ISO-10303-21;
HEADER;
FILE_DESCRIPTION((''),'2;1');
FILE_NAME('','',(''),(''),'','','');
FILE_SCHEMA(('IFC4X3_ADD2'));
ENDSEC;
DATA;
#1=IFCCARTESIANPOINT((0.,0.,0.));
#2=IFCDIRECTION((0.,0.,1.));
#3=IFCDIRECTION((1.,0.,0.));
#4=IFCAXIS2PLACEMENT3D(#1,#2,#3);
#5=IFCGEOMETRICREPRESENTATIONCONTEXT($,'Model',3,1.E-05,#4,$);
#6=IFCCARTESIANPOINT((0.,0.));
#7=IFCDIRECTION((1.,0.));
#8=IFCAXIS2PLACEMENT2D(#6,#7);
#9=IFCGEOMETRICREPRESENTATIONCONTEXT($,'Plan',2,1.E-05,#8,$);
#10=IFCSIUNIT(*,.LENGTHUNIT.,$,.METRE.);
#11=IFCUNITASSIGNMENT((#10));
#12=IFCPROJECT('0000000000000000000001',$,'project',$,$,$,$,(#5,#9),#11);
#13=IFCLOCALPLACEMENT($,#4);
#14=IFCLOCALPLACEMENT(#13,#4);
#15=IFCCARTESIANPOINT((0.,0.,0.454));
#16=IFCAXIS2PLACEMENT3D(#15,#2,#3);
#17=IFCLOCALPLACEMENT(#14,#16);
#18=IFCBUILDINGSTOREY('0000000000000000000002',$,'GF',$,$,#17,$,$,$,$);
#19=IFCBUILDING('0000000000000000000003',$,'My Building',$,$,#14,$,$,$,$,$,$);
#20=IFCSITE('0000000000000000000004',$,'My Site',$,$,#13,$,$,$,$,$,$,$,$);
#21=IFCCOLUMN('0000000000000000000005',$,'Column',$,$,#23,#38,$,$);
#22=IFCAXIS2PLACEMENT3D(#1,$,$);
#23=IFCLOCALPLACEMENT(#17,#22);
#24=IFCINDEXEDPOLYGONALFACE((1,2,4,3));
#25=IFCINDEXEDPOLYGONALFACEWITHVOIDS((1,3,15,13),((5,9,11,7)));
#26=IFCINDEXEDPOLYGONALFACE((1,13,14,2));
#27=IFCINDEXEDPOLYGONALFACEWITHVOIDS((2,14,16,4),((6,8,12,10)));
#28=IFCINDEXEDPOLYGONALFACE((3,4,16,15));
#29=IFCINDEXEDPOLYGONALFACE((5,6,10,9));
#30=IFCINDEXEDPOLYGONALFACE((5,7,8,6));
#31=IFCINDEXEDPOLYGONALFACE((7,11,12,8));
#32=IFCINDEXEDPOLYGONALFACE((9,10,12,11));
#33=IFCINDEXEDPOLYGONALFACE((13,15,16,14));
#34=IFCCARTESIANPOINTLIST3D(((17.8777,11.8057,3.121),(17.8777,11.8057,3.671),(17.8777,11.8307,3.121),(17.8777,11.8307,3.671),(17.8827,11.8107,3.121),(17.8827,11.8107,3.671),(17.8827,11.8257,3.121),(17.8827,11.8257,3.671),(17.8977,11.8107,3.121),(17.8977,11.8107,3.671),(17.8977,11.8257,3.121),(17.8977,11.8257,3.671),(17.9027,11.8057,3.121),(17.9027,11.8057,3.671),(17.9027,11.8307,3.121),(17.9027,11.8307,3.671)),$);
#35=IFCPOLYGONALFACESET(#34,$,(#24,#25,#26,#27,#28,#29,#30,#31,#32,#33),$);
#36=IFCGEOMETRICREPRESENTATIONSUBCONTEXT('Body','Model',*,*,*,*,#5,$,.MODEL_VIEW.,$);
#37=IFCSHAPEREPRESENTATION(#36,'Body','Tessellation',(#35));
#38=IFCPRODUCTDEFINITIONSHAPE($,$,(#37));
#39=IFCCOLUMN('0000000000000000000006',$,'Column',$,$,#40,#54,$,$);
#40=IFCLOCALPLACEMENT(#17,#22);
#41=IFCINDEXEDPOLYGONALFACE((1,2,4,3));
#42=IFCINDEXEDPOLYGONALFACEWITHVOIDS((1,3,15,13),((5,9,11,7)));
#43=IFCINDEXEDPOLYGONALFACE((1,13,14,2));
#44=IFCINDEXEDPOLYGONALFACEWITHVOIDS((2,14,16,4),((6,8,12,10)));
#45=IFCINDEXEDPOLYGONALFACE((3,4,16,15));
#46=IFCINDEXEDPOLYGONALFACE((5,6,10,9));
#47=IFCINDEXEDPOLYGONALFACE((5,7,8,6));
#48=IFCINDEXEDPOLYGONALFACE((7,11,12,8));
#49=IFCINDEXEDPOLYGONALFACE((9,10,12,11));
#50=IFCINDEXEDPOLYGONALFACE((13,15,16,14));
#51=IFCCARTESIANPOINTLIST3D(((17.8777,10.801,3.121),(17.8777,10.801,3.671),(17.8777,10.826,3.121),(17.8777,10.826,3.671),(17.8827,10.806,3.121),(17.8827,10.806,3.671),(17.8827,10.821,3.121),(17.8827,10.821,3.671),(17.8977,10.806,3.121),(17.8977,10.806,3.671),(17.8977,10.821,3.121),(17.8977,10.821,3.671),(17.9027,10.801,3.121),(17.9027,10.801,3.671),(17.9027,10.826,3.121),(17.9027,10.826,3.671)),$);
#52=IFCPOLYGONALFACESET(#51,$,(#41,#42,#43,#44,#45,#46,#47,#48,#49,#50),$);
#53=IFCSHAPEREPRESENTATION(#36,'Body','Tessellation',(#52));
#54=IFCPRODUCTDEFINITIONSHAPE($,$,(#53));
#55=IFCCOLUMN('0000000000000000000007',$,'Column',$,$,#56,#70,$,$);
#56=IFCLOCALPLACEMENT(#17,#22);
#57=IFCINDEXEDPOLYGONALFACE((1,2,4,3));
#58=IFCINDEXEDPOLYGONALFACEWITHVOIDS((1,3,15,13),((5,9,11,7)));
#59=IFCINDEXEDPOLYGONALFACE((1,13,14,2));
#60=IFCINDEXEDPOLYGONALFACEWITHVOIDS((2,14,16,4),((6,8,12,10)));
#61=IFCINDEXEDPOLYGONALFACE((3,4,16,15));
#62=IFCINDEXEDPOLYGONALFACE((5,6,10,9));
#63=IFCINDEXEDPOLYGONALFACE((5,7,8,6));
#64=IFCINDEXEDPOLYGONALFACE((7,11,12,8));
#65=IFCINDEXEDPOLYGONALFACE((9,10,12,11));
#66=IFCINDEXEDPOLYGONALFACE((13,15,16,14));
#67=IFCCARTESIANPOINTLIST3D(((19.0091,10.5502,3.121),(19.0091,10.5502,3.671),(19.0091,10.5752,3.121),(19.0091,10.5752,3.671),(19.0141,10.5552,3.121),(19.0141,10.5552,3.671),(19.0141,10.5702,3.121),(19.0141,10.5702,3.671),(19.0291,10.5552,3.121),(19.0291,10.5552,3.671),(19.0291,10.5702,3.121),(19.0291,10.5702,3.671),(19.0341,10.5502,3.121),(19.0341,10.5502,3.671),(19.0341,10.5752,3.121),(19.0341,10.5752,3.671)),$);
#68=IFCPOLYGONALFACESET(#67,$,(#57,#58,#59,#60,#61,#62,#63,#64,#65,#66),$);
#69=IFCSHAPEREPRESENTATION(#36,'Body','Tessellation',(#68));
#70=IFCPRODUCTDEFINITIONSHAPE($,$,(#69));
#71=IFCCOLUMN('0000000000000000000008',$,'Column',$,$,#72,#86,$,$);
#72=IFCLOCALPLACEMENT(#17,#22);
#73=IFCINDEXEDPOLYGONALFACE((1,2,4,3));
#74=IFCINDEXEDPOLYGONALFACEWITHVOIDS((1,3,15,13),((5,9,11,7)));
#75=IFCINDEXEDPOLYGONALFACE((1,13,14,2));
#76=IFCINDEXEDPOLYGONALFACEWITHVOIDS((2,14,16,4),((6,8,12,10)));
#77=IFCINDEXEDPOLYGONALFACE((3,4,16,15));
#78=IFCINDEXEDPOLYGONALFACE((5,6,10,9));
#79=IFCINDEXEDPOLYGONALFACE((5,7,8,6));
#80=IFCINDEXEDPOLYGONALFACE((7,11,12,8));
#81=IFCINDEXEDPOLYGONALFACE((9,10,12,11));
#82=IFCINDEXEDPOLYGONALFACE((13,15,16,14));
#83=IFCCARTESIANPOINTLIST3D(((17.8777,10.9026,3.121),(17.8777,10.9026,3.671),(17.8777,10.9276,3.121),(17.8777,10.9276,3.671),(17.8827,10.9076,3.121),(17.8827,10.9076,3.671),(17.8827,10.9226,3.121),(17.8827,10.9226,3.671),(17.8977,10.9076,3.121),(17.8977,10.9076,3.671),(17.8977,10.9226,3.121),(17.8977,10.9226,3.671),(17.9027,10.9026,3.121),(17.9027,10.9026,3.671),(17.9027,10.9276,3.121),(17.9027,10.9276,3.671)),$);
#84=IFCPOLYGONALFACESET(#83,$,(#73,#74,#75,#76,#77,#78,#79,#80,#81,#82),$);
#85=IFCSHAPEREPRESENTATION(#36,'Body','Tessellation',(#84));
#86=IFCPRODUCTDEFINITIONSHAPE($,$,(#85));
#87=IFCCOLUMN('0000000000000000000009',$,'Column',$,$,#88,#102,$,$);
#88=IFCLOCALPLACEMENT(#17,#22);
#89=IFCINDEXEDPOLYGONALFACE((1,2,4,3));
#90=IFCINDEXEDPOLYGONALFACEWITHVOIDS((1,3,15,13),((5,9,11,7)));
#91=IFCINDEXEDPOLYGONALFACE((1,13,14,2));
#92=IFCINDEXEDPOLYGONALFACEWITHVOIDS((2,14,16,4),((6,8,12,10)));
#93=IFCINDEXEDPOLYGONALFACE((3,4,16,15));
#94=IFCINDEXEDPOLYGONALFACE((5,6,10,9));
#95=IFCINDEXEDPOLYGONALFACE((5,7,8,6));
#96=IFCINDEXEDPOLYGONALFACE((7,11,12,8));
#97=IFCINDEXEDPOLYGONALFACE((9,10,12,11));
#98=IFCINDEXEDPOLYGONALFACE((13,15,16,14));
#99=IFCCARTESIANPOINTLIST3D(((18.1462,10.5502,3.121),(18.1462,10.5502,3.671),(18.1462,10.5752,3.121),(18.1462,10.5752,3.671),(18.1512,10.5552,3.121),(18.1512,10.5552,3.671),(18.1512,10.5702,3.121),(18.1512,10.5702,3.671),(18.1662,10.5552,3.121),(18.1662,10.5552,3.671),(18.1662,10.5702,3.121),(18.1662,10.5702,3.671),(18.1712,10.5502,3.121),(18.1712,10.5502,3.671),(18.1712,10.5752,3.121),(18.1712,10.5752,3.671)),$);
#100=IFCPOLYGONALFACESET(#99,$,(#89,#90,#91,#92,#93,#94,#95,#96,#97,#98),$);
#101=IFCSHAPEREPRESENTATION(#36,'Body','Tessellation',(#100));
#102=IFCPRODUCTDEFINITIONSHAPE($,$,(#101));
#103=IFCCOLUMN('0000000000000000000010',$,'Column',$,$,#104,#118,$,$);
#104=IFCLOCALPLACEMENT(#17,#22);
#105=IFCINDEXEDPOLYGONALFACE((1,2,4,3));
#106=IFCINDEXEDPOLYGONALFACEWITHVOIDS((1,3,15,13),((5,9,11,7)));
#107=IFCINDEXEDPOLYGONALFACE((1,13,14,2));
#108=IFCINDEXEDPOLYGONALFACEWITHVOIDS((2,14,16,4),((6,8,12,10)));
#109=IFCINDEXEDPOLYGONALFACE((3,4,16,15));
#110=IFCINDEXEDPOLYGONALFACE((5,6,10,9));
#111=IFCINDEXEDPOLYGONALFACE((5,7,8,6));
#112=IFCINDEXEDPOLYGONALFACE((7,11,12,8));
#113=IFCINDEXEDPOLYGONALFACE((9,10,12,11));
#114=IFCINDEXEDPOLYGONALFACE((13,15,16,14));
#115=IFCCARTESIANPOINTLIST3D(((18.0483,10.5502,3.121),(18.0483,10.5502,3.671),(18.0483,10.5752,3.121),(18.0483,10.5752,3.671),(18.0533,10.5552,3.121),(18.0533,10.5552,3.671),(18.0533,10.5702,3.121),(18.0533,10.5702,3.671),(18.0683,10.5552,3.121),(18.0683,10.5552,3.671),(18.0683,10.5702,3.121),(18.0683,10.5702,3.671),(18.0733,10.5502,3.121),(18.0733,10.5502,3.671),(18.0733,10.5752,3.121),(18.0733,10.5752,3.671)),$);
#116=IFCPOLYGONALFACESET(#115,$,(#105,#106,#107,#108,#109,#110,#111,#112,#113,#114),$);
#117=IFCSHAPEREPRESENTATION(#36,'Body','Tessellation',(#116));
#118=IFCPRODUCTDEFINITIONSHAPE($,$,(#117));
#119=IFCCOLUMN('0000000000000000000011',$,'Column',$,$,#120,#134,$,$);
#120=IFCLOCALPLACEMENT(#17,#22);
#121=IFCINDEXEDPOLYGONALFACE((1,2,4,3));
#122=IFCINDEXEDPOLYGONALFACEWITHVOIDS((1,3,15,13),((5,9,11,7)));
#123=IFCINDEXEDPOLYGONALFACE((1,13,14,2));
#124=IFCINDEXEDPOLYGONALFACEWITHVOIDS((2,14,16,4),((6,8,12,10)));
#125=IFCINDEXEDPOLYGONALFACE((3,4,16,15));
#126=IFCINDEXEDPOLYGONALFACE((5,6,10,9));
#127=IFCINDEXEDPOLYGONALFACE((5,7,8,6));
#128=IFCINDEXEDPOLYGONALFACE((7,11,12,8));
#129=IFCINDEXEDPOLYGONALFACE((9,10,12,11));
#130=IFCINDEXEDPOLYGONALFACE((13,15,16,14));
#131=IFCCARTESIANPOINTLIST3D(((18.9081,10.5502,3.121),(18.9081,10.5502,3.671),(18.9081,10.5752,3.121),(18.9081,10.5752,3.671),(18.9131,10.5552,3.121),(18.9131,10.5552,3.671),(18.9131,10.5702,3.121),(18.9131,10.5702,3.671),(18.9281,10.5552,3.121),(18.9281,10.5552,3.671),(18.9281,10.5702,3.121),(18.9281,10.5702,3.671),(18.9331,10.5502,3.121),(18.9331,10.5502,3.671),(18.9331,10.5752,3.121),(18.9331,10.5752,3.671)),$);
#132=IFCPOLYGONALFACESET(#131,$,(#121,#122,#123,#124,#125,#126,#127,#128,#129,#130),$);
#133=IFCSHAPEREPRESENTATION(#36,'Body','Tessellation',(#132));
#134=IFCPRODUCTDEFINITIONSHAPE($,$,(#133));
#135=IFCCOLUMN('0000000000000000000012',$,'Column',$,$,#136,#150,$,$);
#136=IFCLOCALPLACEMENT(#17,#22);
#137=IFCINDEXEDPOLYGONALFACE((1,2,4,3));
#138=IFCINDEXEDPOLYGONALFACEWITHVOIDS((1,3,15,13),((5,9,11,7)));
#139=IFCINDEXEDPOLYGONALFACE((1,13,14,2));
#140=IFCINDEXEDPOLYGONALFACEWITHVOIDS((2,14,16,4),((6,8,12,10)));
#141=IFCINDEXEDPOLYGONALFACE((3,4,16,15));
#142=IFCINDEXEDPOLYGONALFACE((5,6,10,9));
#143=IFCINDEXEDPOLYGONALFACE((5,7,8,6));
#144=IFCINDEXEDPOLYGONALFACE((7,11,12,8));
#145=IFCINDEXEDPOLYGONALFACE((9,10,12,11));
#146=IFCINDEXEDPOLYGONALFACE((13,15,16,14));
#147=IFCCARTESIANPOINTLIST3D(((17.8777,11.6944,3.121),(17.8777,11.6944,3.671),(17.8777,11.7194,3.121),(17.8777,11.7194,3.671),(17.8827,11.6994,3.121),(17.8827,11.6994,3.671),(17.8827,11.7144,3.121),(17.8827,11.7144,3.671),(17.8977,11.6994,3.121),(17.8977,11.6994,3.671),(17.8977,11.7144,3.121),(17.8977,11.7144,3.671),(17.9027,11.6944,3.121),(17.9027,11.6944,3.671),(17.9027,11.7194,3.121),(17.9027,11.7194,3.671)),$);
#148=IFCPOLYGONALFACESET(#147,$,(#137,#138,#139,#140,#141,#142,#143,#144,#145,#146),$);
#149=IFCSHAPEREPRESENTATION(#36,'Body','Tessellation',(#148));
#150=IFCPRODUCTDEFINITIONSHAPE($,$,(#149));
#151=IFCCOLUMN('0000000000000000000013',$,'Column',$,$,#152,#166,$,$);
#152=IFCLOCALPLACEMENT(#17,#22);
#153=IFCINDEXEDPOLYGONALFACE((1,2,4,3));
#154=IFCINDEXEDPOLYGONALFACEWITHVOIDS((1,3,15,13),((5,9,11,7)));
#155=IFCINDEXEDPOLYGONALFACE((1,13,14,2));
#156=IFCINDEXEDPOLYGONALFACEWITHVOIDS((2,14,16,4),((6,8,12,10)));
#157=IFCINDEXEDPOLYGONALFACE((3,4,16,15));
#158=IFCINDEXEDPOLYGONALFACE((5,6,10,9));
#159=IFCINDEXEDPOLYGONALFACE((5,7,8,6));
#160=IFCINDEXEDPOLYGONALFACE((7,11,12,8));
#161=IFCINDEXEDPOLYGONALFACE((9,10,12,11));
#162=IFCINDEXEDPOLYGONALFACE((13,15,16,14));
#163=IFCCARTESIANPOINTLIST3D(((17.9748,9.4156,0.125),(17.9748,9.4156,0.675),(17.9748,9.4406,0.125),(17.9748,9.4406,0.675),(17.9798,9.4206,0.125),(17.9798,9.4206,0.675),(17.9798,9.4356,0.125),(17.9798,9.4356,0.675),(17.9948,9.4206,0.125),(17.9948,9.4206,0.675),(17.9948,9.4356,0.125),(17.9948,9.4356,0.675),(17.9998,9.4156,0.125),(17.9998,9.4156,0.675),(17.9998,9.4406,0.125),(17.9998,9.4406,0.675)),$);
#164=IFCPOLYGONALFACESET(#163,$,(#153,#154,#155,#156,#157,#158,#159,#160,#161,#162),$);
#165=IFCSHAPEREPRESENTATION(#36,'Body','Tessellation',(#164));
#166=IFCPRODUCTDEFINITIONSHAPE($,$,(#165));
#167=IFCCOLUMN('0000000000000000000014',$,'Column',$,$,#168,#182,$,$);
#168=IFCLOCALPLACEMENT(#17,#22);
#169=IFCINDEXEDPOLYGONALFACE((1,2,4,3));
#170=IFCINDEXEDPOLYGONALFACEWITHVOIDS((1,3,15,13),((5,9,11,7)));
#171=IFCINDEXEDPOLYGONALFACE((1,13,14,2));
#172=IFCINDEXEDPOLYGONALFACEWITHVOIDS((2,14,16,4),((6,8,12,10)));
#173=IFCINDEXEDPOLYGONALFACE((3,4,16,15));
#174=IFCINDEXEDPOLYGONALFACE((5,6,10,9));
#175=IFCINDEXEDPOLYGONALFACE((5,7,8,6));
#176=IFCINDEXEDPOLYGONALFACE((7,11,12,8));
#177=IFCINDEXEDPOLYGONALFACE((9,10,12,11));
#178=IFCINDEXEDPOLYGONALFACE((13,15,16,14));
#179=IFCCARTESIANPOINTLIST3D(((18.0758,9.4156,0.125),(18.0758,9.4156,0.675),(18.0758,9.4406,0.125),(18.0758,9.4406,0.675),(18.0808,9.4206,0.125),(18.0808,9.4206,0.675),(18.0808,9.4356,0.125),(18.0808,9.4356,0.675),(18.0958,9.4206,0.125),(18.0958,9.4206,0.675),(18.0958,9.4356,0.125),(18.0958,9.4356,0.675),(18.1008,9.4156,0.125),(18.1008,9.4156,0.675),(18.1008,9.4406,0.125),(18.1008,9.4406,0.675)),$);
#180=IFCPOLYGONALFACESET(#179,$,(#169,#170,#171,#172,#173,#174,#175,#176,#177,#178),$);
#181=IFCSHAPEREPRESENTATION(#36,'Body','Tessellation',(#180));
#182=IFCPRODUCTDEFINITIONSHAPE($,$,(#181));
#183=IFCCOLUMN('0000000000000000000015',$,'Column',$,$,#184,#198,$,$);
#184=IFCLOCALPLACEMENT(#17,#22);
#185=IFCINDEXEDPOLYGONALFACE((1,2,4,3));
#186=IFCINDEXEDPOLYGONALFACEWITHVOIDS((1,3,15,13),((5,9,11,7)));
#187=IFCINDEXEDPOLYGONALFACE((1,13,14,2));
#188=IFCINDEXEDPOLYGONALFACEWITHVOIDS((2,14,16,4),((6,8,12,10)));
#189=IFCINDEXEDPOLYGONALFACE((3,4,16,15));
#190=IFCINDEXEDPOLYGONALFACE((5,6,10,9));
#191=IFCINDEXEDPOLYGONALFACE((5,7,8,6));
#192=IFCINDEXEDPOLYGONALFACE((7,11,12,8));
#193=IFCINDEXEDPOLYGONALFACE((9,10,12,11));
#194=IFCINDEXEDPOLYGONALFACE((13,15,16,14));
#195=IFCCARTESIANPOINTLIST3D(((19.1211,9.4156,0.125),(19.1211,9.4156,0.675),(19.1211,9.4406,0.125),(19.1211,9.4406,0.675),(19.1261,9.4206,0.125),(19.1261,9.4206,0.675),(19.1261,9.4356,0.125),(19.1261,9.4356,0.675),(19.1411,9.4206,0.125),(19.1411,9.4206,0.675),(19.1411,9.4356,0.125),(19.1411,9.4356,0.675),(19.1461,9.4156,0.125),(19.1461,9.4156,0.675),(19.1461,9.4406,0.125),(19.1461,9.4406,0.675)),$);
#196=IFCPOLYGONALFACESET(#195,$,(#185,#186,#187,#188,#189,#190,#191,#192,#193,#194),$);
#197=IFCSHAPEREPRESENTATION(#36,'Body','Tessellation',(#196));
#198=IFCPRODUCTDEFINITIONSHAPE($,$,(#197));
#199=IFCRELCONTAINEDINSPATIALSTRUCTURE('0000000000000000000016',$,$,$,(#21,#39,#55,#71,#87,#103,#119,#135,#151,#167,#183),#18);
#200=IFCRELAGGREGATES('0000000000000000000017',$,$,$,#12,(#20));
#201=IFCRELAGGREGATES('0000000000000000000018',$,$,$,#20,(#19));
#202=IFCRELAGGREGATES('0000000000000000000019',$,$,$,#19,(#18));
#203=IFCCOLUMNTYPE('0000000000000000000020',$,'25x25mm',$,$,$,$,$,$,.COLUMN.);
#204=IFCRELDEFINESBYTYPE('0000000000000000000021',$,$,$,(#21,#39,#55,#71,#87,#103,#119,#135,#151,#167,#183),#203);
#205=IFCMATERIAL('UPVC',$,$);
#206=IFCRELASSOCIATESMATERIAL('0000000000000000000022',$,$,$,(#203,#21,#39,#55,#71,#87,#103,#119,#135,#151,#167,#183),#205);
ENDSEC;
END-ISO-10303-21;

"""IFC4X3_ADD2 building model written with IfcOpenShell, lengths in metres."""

from ifc_helpers import new_model, si_unit, frame, origin_with_axes, origin_2d_with_axis, place, context, subcontext, project, spatial, hollow_rectangle, extrude, material, material_profile, profile_set, profile_usage, type_object, element, save


model = new_model("IFC4X3_ADD2")

# Units and contexts
model_context = context("Model", 3, precision=1e-05, world=origin_with_axes())
plan_context = context("Plan", 2, precision=1e-05, world=origin_2d_with_axis())
body_context = subcontext(model_context, "Body", "Model", "MODEL_VIEW")
ifc_project = project(units=[si_unit("LENGTHUNIT", "METRE")], contexts=[model_context, plan_context])

# Site, building, storey
site_placement = place(None, origin_with_axes())
site = spatial("IfcSite", under=ifc_project, at=site_placement, Name="My Site")
building_placement = place(site_placement, origin_with_axes())
building = spatial("IfcBuilding", under=site, at=building_placement, Name="My Building")
storey_placement = place(building_placement, frame((0.0, 0.0, 0.454), z_axis=(0.0, 0.0, 1.0), x_axis=(1.0, 0.0, 0.0)))
storey = spatial("IfcBuildingStorey", under=building, at=storey_placement, Name="GF")

# Columns
ifc_material = material(Name="UPVC")
ifc_material_profile_1 = material_profile(ifc_material, hollow_rectangle(XDim=0.025, YDim=0.025, WallThickness=0.005))
ifc_profile_set_1 = profile_set([ifc_material_profile_1])
ifc_profile_usage_1 = profile_usage(ifc_profile_set_1)
column_type_1 = type_object("IfcColumnType", Name="25x25mm", PredefinedType="COLUMN", material=ifc_profile_set_1)
column_1_placement = place(storey_placement, frame((17.8902, 11.8182, 3.121), z_axis=(0.0, 0.0, 1.0), x_axis=(0.0, -1.0, 0.0)))
element("IfcColumn", 1, at=column_1_placement, inside=storey, type_object=column_type_1, material=ifc_profile_usage_1, Name="Column", context=body_context, shape_type="SweptSolid", body=[
    extrude(hollow_rectangle(XDim=0.025, YDim=0.025, WallThickness=0.005), origin_with_axes(), (0.0, 0.0, 1.0), 0.55),
])
ifc_profile_usage_2 = profile_usage(ifc_profile_set_1)
column_2_placement = place(storey_placement, frame((17.8902, 10.8135, 3.121), z_axis=(0.0, 0.0, 1.0), x_axis=(0.0, -1.0, 0.0)))
element("IfcColumn", 2, at=column_2_placement, inside=storey, type_object=column_type_1, material=ifc_profile_usage_2, Name="Column", context=body_context, shape_type="SweptSolid", body=[
    extrude(hollow_rectangle(XDim=0.025, YDim=0.025, WallThickness=0.005), origin_with_axes(), (0.0, 0.0, 1.0), 0.55),
])
ifc_profile_usage_3 = profile_usage(ifc_profile_set_1)
column_3_placement = place(storey_placement, frame((19.0216, 10.5627, 3.121), z_axis=(0.0, 0.0, 1.0), x_axis=(0.0, -1.0, 0.0)))
element("IfcColumn", 3, at=column_3_placement, inside=storey, type_object=column_type_1, material=ifc_profile_usage_3, Name="Column", context=body_context, shape_type="SweptSolid", body=[
    extrude(hollow_rectangle(XDim=0.025, YDim=0.025, WallThickness=0.005), origin_with_axes(), (0.0, 0.0, 1.0), 0.55),
])
ifc_profile_usage_4 = profile_usage(ifc_profile_set_1)
column_4_placement = place(storey_placement, frame((17.8902, 10.9151, 3.121), z_axis=(0.0, 0.0, 1.0), x_axis=(0.0, -1.0, 0.0)))
element("IfcColumn", 4, at=column_4_placement, inside=storey, type_object=column_type_1, material=ifc_profile_usage_4, Name="Column", context=body_context, shape_type="SweptSolid", body=[
    extrude(hollow_rectangle(XDim=0.025, YDim=0.025, WallThickness=0.005), origin_with_axes(), (0.0, 0.0, 1.0), 0.55),
])
ifc_profile_usage_5 = profile_usage(ifc_profile_set_1)
column_5_placement = place(storey_placement, frame((18.1587, 10.5627, 3.121), z_axis=(0.0, 0.0, 1.0), x_axis=(0.0, -1.0, 0.0)))
element("IfcColumn", 5, at=column_5_placement, inside=storey, type_object=column_type_1, material=ifc_profile_usage_5, Name="Column", context=body_context, shape_type="SweptSolid", body=[
    extrude(hollow_rectangle(XDim=0.025, YDim=0.025, WallThickness=0.005), origin_with_axes(), (0.0, 0.0, 1.0), 0.55),
])
ifc_profile_usage_6 = profile_usage(ifc_profile_set_1)
column_6_placement = place(storey_placement, frame((18.0608, 10.5627, 3.121), z_axis=(0.0, 0.0, 1.0), x_axis=(0.0, -1.0, 0.0)))
element("IfcColumn", 6, at=column_6_placement, inside=storey, type_object=column_type_1, material=ifc_profile_usage_6, Name="Column", context=body_context, shape_type="SweptSolid", body=[
    extrude(hollow_rectangle(XDim=0.025, YDim=0.025, WallThickness=0.005), origin_with_axes(), (0.0, 0.0, 1.0), 0.55),
])
ifc_profile_usage_7 = profile_usage(ifc_profile_set_1)
column_7_placement = place(storey_placement, frame((18.9206, 10.5627, 3.121), z_axis=(0.0, 0.0, 1.0), x_axis=(0.0, -1.0, 0.0)))
element("IfcColumn", 7, at=column_7_placement, inside=storey, type_object=column_type_1, material=ifc_profile_usage_7, Name="Column", context=body_context, shape_type="SweptSolid", body=[
    extrude(hollow_rectangle(XDim=0.025, YDim=0.025, WallThickness=0.005), origin_with_axes(), (0.0, 0.0, 1.0), 0.55),
])
ifc_profile_usage_8 = profile_usage(ifc_profile_set_1)
column_8_placement = place(storey_placement, frame((17.8902, 11.7069, 3.121), z_axis=(0.0, 0.0, 1.0), x_axis=(0.0, -1.0, 0.0)))
element("IfcColumn", 8, at=column_8_placement, inside=storey, type_object=column_type_1, material=ifc_profile_usage_8, Name="Column", context=body_context, shape_type="SweptSolid", body=[
    extrude(hollow_rectangle(XDim=0.025, YDim=0.025, WallThickness=0.005), origin_with_axes(), (0.0, 0.0, 1.0), 0.55),
])
ifc_profile_usage_9 = profile_usage(ifc_profile_set_1)
column_9_placement = place(storey_placement, frame((17.9873, 9.4281, 0.125), z_axis=(0.0, 0.0, 1.0), x_axis=(0.0, -1.0, 0.0)))
element("IfcColumn", 9, at=column_9_placement, inside=storey, type_object=column_type_1, material=ifc_profile_usage_9, Name="Column", context=body_context, shape_type="SweptSolid", body=[
    extrude(hollow_rectangle(XDim=0.025, YDim=0.025, WallThickness=0.005), origin_with_axes(), (0.0, 0.0, 1.0), 0.55),
])
ifc_profile_usage_10 = profile_usage(ifc_profile_set_1)
column_10_placement = place(storey_placement, frame((18.0883, 9.4281, 0.125), z_axis=(0.0, 0.0, 1.0), x_axis=(0.0, -1.0, 0.0)))
element("IfcColumn", 10, at=column_10_placement, inside=storey, type_object=column_type_1, material=ifc_profile_usage_10, Name="Column", context=body_context, shape_type="SweptSolid", body=[
    extrude(hollow_rectangle(XDim=0.025, YDim=0.025, WallThickness=0.005), origin_with_axes(), (0.0, 0.0, 1.0), 0.55),
])
ifc_profile_usage_11 = profile_usage(ifc_profile_set_1)
column_11_placement = place(storey_placement, frame((19.1336, 9.4281, 0.125), z_axis=(0.0, 0.0, 1.0), x_axis=(0.0, -1.0, 0.0)))
element("IfcColumn", 11, at=column_11_placement, inside=storey, type_object=column_type_1, material=ifc_profile_usage_11, Name="Column", context=body_context, shape_type="SweptSolid", body=[
    extrude(hollow_rectangle(XDim=0.025, YDim=0.025, WallThickness=0.005), origin_with_axes(), (0.0, 0.0, 1.0), 0.55),
])

save(model, "model.ifc")
